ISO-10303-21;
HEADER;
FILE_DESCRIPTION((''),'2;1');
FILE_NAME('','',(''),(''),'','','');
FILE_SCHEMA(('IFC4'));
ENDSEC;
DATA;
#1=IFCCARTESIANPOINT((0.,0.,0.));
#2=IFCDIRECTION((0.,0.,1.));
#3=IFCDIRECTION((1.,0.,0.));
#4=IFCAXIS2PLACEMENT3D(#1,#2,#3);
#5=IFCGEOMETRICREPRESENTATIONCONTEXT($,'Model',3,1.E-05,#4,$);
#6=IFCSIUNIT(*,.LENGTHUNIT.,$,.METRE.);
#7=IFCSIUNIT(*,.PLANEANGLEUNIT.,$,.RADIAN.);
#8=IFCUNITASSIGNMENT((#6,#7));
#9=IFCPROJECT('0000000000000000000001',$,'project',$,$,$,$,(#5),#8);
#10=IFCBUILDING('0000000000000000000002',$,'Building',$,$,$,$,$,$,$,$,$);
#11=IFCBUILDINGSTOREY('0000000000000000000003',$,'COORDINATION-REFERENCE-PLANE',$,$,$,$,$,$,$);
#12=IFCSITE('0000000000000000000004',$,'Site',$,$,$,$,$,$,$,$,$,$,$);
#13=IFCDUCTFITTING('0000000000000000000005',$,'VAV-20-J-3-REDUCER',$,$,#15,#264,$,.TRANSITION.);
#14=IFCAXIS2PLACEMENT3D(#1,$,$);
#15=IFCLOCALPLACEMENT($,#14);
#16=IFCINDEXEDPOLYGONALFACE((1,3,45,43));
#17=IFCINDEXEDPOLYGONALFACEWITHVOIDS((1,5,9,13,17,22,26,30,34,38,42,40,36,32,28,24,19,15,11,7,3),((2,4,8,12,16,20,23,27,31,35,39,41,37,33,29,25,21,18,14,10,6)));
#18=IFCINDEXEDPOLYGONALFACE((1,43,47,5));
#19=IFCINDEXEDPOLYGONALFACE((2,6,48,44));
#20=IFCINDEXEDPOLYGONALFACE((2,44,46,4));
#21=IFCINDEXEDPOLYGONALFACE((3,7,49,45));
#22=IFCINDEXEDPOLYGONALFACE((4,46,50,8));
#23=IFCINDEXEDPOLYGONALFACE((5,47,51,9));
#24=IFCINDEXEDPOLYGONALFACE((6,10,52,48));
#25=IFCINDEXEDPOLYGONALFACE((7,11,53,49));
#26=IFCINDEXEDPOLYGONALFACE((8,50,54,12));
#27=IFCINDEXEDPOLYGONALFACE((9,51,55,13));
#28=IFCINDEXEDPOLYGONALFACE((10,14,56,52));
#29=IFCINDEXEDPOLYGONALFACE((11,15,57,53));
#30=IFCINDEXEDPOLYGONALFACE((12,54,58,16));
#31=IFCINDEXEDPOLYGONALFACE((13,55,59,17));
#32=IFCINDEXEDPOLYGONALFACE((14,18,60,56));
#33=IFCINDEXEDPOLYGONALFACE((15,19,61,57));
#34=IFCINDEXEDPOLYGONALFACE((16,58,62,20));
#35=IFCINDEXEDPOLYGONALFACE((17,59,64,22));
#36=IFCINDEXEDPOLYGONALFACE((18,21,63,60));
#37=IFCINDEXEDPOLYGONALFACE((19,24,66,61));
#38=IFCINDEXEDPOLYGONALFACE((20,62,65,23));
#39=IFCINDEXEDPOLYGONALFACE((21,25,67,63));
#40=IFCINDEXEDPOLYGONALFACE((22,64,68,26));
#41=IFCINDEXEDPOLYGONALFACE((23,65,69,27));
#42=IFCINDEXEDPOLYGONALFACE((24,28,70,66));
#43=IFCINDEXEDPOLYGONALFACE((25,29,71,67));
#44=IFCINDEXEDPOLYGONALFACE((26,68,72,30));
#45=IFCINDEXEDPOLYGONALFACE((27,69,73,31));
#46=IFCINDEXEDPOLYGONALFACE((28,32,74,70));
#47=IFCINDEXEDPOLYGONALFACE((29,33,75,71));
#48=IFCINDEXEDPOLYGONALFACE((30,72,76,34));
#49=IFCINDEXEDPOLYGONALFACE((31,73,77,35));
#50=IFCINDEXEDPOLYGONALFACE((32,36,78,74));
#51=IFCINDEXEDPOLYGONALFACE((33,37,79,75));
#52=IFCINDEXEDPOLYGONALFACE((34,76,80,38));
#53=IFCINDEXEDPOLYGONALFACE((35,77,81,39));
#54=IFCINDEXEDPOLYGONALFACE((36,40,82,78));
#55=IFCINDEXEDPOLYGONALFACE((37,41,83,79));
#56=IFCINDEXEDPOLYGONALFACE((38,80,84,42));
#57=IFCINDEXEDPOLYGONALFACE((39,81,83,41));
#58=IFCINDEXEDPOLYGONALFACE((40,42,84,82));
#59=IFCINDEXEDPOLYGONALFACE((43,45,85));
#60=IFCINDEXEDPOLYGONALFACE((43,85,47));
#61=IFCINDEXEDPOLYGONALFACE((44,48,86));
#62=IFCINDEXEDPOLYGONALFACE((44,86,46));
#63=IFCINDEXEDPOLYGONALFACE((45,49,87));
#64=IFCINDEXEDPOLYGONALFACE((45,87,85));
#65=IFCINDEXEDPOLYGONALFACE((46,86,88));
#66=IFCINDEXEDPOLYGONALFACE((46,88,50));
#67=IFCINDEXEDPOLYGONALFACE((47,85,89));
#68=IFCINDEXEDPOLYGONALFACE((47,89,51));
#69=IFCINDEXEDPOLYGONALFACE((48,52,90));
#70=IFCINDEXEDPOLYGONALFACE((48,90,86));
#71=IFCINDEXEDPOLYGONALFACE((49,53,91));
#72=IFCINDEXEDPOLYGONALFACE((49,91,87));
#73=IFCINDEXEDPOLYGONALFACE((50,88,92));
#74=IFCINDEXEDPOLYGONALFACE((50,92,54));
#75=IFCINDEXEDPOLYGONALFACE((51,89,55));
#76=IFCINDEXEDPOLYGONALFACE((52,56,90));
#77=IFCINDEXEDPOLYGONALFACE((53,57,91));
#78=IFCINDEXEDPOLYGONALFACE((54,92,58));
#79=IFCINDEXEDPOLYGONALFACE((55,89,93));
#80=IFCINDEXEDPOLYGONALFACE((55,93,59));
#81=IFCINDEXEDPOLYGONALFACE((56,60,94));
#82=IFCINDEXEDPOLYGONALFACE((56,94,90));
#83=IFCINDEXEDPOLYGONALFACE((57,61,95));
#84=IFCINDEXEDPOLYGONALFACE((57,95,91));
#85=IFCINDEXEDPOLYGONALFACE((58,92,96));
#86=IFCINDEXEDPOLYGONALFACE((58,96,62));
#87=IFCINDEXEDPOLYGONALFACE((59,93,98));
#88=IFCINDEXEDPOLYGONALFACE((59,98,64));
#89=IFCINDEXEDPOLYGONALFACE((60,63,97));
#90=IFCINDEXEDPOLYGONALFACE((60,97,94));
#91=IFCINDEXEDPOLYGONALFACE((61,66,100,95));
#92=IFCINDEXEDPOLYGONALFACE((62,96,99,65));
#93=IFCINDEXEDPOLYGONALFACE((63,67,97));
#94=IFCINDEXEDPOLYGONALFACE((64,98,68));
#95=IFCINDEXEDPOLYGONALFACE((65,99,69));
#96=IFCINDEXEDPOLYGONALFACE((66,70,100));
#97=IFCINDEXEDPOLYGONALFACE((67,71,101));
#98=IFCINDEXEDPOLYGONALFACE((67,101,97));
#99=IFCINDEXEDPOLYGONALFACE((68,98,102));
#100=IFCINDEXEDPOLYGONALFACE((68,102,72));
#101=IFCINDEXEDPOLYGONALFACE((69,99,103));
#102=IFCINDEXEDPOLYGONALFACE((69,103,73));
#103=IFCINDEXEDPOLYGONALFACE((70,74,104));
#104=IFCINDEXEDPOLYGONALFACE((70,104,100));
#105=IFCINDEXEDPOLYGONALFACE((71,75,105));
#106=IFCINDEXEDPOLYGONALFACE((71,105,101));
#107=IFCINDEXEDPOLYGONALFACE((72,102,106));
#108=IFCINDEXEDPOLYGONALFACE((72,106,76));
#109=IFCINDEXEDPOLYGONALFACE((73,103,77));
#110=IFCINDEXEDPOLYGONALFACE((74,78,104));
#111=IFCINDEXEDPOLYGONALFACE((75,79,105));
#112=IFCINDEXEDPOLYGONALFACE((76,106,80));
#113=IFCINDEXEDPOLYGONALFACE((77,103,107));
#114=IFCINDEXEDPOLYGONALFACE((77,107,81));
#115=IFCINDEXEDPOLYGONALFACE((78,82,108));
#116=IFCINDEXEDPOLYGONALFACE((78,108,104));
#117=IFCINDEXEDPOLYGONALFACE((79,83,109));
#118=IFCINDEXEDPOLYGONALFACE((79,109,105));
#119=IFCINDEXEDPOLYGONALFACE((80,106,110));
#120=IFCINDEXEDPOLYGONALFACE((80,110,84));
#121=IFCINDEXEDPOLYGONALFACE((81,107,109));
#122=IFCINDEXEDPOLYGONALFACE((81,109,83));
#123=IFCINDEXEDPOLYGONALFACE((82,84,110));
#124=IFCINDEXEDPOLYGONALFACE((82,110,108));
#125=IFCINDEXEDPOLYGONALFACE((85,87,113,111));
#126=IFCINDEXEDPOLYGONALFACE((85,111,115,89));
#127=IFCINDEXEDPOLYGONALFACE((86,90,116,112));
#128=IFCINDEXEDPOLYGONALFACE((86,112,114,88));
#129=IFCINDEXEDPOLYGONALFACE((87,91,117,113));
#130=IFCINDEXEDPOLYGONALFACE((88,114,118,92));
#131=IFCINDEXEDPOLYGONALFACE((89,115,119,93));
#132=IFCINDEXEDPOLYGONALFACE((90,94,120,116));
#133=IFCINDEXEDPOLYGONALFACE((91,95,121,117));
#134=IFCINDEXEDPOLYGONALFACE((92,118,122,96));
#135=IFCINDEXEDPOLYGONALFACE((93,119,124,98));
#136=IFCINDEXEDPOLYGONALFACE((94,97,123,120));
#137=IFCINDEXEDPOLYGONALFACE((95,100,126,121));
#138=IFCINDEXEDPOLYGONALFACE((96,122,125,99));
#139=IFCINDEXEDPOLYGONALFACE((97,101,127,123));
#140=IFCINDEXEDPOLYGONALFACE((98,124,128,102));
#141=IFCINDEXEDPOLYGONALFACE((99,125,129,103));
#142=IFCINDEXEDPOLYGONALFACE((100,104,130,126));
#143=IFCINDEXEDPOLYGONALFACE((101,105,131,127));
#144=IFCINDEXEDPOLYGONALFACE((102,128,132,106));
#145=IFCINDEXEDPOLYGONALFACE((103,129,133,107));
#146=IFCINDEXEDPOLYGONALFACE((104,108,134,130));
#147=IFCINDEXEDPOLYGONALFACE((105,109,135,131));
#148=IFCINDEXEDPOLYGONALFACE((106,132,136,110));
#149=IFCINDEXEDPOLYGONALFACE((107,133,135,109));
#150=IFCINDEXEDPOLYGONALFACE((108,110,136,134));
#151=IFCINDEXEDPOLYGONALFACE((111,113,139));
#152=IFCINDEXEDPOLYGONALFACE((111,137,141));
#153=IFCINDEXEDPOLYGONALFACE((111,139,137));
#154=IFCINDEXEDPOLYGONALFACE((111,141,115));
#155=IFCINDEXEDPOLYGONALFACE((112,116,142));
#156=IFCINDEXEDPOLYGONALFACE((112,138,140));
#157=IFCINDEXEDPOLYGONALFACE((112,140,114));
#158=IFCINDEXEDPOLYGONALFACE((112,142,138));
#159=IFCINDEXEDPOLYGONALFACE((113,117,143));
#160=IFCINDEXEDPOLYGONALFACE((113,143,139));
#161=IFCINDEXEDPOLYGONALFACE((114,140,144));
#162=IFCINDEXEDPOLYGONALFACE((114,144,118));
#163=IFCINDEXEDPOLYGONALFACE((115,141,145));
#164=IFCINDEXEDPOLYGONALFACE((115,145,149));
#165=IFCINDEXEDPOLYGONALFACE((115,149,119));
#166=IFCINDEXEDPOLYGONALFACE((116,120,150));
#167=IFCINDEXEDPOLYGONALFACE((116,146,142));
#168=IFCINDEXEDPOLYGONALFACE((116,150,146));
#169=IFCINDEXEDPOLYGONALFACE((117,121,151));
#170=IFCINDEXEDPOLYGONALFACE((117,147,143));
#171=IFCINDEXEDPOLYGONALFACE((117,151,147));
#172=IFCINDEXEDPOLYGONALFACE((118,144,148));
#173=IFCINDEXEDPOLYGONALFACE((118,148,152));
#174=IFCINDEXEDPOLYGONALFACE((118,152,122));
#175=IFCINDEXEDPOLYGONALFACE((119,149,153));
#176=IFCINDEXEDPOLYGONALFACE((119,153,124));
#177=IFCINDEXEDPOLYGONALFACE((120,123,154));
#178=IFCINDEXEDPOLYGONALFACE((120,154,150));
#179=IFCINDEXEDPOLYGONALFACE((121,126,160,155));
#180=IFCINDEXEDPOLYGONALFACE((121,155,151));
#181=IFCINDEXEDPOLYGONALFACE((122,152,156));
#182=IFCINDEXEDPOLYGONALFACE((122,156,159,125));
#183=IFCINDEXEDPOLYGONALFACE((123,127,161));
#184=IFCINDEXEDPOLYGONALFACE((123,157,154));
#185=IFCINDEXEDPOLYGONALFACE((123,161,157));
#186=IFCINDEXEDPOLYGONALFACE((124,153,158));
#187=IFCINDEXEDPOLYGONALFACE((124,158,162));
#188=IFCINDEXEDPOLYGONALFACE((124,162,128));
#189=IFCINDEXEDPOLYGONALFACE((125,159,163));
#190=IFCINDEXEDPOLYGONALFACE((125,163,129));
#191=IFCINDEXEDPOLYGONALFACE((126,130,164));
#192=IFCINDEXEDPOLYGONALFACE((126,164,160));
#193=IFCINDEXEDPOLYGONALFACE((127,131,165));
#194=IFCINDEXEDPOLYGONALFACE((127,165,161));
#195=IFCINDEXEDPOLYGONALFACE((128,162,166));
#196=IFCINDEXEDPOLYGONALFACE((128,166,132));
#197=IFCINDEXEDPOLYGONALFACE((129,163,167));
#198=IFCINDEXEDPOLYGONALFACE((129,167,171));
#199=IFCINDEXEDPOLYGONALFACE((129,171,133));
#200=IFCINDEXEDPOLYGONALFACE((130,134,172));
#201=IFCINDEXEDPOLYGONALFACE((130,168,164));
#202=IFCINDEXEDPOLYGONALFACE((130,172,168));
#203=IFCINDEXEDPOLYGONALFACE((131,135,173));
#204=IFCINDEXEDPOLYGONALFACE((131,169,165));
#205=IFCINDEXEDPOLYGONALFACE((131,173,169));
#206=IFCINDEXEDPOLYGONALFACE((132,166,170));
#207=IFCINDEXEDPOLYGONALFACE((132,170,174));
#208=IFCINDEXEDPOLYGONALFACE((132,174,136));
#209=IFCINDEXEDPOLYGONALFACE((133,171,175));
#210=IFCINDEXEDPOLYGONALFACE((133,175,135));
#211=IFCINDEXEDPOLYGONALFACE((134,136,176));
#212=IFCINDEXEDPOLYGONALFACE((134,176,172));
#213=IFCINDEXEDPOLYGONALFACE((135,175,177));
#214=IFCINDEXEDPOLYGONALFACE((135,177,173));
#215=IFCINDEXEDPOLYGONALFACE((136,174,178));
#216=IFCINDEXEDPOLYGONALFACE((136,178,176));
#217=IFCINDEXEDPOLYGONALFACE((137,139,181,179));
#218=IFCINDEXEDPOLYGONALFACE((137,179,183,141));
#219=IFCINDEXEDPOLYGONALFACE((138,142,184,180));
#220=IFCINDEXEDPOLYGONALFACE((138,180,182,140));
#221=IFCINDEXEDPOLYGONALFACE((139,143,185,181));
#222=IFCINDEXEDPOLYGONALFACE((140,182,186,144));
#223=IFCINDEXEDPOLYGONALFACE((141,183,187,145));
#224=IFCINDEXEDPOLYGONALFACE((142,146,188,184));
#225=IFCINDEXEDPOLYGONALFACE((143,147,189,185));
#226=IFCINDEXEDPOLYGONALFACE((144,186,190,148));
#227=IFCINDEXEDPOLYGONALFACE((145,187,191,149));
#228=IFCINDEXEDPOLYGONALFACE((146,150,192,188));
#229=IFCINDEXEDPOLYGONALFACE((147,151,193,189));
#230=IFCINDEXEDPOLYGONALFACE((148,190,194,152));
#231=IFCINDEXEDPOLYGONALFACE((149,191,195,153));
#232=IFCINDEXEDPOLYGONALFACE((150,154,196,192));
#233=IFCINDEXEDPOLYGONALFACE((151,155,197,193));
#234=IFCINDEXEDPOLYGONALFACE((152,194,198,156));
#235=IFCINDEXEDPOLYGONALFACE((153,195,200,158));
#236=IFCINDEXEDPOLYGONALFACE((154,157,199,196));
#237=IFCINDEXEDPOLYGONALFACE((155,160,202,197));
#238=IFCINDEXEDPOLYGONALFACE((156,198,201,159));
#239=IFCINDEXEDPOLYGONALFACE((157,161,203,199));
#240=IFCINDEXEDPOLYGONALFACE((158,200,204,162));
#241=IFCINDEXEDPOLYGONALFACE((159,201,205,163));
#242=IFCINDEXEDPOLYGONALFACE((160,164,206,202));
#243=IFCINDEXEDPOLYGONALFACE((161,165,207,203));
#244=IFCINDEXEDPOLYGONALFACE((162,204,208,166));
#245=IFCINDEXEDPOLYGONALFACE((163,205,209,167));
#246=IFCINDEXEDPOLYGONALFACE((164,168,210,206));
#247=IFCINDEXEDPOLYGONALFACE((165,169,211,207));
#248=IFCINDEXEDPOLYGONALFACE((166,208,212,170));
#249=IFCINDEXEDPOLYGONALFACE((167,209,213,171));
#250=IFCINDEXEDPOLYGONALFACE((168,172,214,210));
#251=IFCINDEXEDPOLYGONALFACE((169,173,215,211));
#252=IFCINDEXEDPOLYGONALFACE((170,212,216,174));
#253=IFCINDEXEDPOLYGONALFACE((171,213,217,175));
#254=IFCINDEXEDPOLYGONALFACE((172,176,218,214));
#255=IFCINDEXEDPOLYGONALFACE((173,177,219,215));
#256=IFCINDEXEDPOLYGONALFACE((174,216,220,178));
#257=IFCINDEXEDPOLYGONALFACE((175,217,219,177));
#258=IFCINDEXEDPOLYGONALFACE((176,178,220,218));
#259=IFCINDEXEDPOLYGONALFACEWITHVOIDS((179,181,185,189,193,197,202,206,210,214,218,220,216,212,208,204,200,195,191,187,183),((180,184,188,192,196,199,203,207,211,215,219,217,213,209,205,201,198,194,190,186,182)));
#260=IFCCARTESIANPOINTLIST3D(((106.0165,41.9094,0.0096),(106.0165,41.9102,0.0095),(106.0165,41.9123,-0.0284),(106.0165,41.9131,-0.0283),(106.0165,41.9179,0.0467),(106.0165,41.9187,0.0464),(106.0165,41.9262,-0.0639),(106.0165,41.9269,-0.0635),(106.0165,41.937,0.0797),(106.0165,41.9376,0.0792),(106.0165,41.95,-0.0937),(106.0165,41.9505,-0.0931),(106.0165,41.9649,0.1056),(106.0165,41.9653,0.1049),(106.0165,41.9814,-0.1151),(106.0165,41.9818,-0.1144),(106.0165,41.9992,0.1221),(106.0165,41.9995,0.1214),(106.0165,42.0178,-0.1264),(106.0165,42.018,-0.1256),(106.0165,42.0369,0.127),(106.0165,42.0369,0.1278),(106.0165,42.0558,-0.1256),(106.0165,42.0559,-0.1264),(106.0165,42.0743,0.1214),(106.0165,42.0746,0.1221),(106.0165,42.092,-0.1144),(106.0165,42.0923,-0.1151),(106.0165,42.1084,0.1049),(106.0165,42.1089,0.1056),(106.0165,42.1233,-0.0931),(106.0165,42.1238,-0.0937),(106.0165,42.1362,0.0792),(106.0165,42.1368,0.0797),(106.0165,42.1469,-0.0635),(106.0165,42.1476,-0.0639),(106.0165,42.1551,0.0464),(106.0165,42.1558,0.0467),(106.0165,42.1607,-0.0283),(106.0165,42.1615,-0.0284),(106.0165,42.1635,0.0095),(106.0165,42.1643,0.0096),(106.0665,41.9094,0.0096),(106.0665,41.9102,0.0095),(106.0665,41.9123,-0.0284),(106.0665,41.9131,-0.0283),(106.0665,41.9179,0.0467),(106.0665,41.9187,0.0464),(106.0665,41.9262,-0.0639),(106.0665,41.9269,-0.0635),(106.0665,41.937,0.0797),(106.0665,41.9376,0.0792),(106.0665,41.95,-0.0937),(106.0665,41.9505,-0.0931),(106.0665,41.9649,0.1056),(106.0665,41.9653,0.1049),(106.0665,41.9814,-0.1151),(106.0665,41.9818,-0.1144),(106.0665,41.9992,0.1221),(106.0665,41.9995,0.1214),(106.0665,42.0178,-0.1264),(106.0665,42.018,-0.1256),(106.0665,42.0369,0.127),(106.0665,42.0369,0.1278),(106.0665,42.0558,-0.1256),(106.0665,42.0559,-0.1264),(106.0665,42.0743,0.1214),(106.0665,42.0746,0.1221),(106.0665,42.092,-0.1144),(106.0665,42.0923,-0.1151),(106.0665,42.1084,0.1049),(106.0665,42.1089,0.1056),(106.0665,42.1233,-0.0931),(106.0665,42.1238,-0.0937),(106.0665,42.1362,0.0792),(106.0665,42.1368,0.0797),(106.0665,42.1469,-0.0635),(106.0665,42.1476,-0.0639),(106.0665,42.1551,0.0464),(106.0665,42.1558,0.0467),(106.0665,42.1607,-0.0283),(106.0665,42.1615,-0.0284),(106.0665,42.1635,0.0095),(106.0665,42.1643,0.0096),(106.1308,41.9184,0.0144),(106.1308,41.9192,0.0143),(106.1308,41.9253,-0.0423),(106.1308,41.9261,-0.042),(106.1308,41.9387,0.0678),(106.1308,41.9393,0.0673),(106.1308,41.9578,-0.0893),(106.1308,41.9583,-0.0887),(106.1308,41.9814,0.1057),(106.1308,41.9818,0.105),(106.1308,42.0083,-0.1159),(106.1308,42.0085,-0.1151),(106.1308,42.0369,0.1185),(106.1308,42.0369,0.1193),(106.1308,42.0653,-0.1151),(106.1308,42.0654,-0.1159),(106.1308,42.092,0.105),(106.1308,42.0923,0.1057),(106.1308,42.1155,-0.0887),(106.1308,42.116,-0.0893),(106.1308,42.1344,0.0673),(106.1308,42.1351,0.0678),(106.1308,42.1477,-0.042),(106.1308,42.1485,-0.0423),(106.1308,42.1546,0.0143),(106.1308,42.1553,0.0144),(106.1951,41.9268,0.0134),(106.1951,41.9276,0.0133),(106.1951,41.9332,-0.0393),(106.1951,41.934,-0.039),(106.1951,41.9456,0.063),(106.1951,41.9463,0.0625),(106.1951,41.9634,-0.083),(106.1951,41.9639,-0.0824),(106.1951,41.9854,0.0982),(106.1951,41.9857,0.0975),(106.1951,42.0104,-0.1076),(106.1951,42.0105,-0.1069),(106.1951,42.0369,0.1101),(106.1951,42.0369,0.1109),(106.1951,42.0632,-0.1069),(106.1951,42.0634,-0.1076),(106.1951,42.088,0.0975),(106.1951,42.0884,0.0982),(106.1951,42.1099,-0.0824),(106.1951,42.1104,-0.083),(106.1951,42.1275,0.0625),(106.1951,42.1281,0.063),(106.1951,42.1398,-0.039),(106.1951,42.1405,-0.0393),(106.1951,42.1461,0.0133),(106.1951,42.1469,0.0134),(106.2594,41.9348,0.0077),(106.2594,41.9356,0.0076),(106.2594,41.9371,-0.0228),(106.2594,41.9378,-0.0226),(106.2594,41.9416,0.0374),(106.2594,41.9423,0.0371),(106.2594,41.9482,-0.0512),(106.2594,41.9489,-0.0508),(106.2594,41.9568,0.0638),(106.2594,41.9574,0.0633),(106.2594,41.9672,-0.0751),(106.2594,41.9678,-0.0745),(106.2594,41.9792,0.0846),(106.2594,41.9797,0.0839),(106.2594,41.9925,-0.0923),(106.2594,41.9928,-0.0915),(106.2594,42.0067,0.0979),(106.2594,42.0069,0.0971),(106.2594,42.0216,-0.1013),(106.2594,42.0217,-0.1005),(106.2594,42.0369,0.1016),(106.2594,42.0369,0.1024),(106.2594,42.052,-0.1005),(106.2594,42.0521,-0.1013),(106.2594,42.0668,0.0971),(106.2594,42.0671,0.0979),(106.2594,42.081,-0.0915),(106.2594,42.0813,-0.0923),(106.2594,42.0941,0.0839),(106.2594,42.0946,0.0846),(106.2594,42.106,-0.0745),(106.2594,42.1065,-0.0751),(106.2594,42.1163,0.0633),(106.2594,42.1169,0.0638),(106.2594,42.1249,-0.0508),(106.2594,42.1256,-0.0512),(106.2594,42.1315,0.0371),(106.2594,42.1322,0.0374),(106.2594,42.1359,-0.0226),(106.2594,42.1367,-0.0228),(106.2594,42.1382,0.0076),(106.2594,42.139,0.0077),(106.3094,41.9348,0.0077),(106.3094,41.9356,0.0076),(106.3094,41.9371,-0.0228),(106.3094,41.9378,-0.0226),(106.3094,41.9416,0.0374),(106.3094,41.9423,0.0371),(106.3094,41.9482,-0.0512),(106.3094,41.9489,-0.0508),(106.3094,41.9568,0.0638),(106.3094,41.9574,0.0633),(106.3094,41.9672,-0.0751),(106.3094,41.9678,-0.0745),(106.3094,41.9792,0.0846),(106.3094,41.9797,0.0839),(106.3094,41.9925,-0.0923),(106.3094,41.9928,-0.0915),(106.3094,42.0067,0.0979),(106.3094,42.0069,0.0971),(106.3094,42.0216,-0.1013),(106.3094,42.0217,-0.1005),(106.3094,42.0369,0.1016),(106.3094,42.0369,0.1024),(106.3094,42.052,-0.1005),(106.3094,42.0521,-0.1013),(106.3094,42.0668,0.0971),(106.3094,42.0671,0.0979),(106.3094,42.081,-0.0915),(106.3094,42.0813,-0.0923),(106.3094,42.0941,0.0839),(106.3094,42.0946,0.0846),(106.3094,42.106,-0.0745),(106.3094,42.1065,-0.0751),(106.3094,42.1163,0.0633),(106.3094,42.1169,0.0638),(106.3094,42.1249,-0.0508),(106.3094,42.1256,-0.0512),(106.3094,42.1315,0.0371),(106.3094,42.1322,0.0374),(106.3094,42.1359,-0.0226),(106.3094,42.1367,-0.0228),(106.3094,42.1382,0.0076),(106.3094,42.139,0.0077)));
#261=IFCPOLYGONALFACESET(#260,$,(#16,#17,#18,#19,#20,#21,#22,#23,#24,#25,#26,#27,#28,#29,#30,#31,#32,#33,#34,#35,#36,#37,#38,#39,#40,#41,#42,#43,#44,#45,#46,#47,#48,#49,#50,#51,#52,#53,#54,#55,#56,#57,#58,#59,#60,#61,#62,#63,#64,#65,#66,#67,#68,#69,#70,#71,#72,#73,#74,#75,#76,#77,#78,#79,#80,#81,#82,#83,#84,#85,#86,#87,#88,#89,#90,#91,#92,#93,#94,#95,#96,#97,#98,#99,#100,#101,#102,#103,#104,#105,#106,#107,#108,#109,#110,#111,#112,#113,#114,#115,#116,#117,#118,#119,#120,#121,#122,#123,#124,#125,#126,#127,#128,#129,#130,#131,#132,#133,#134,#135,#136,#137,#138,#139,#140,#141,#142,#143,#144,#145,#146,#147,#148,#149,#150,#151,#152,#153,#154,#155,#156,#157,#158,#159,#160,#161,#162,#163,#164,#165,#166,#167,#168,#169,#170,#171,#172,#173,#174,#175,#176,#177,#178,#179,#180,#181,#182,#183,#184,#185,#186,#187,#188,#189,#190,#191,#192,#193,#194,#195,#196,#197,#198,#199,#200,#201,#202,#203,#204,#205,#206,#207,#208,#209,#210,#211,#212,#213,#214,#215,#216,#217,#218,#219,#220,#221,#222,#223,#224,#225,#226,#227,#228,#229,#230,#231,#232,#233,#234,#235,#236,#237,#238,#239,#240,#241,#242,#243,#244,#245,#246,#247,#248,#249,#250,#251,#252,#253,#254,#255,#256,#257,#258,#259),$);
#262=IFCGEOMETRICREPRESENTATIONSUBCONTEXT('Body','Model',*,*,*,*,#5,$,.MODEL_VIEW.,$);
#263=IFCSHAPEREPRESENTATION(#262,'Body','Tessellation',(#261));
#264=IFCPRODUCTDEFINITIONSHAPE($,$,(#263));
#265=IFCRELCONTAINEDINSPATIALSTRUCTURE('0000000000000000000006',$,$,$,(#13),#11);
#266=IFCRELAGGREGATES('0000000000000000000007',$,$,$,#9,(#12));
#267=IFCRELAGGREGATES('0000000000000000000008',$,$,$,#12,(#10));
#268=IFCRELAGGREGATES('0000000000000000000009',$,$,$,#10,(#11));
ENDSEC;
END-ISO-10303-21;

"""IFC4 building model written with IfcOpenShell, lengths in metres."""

from ifc_helpers import new_model, entity, si_unit, frame, origin_with_axes, place, context, subcontext, project, spatial, element, save


model = new_model("IFC4")

# Units and contexts
model_context = context("Model", 3, precision=1e-05, world=origin_with_axes())
body_context_1 = subcontext(model_context, "Body", "Model", "MODEL_VIEW")
ifc_project = project(units=[si_unit("LENGTHUNIT", "METRE"), si_unit("PLANEANGLEUNIT", "RADIAN")], contexts=[model_context])

# Site, building, storey
site = spatial("IfcSite", under=ifc_project, Name="Site")
building = spatial("IfcBuilding", under=site, Name="Building")
storey = spatial("IfcBuildingStorey", under=building, Name="COORDINATION-REFERENCE-PLANE")

# Duct fitting
for number, where, z_axis, x_axis, name in (
    (1, (106.0165, 42.0369, 0.0), (0.0, 1.0, 0.0), (0.0, 0.0, 1.0), "VAV-20-J-3-REDUCER"),
):
    element("IfcDuctFitting", number, at=place(None, frame(where, z_axis=z_axis, x_axis=x_axis)), inside=storey, Name=name, PredefinedType="TRANSITION", context=body_context_1, shape_type="SweptSolid", body=[
        entity("IfcRevolvedAreaSolid", entity("IfcArbitraryClosedProfileDef", "AREA", None, entity("IfcPolyline", [entity("IfcCartesianPoint", [0.1278, 0.0]), entity("IfcCartesianPoint", [0.1278, 0.05]), entity("IfcCartesianPoint", [0.1024, 0.2429]), entity("IfcCartesianPoint", [0.1024, 0.2929]), entity("IfcCartesianPoint", [0.1016, 0.2929]), entity("IfcCartesianPoint", [0.1016, 0.2429]), entity("IfcCartesianPoint", [0.127, 0.05]), entity("IfcCartesianPoint", [0.127, 0.0]), entity("IfcCartesianPoint", [0.1278, 0.0])])), entity("IfcAxis2Placement3D", entity("IfcCartesianPoint", [0.0, 0.0, 0.0])), entity("IfcAxis1Placement", entity("IfcCartesianPoint", [0.0, 0.0, 0.0]), entity("IfcDirection", [0.0, 1.0, 0.0])), 6.283185),
    ])

save(model, "model.ifc")
